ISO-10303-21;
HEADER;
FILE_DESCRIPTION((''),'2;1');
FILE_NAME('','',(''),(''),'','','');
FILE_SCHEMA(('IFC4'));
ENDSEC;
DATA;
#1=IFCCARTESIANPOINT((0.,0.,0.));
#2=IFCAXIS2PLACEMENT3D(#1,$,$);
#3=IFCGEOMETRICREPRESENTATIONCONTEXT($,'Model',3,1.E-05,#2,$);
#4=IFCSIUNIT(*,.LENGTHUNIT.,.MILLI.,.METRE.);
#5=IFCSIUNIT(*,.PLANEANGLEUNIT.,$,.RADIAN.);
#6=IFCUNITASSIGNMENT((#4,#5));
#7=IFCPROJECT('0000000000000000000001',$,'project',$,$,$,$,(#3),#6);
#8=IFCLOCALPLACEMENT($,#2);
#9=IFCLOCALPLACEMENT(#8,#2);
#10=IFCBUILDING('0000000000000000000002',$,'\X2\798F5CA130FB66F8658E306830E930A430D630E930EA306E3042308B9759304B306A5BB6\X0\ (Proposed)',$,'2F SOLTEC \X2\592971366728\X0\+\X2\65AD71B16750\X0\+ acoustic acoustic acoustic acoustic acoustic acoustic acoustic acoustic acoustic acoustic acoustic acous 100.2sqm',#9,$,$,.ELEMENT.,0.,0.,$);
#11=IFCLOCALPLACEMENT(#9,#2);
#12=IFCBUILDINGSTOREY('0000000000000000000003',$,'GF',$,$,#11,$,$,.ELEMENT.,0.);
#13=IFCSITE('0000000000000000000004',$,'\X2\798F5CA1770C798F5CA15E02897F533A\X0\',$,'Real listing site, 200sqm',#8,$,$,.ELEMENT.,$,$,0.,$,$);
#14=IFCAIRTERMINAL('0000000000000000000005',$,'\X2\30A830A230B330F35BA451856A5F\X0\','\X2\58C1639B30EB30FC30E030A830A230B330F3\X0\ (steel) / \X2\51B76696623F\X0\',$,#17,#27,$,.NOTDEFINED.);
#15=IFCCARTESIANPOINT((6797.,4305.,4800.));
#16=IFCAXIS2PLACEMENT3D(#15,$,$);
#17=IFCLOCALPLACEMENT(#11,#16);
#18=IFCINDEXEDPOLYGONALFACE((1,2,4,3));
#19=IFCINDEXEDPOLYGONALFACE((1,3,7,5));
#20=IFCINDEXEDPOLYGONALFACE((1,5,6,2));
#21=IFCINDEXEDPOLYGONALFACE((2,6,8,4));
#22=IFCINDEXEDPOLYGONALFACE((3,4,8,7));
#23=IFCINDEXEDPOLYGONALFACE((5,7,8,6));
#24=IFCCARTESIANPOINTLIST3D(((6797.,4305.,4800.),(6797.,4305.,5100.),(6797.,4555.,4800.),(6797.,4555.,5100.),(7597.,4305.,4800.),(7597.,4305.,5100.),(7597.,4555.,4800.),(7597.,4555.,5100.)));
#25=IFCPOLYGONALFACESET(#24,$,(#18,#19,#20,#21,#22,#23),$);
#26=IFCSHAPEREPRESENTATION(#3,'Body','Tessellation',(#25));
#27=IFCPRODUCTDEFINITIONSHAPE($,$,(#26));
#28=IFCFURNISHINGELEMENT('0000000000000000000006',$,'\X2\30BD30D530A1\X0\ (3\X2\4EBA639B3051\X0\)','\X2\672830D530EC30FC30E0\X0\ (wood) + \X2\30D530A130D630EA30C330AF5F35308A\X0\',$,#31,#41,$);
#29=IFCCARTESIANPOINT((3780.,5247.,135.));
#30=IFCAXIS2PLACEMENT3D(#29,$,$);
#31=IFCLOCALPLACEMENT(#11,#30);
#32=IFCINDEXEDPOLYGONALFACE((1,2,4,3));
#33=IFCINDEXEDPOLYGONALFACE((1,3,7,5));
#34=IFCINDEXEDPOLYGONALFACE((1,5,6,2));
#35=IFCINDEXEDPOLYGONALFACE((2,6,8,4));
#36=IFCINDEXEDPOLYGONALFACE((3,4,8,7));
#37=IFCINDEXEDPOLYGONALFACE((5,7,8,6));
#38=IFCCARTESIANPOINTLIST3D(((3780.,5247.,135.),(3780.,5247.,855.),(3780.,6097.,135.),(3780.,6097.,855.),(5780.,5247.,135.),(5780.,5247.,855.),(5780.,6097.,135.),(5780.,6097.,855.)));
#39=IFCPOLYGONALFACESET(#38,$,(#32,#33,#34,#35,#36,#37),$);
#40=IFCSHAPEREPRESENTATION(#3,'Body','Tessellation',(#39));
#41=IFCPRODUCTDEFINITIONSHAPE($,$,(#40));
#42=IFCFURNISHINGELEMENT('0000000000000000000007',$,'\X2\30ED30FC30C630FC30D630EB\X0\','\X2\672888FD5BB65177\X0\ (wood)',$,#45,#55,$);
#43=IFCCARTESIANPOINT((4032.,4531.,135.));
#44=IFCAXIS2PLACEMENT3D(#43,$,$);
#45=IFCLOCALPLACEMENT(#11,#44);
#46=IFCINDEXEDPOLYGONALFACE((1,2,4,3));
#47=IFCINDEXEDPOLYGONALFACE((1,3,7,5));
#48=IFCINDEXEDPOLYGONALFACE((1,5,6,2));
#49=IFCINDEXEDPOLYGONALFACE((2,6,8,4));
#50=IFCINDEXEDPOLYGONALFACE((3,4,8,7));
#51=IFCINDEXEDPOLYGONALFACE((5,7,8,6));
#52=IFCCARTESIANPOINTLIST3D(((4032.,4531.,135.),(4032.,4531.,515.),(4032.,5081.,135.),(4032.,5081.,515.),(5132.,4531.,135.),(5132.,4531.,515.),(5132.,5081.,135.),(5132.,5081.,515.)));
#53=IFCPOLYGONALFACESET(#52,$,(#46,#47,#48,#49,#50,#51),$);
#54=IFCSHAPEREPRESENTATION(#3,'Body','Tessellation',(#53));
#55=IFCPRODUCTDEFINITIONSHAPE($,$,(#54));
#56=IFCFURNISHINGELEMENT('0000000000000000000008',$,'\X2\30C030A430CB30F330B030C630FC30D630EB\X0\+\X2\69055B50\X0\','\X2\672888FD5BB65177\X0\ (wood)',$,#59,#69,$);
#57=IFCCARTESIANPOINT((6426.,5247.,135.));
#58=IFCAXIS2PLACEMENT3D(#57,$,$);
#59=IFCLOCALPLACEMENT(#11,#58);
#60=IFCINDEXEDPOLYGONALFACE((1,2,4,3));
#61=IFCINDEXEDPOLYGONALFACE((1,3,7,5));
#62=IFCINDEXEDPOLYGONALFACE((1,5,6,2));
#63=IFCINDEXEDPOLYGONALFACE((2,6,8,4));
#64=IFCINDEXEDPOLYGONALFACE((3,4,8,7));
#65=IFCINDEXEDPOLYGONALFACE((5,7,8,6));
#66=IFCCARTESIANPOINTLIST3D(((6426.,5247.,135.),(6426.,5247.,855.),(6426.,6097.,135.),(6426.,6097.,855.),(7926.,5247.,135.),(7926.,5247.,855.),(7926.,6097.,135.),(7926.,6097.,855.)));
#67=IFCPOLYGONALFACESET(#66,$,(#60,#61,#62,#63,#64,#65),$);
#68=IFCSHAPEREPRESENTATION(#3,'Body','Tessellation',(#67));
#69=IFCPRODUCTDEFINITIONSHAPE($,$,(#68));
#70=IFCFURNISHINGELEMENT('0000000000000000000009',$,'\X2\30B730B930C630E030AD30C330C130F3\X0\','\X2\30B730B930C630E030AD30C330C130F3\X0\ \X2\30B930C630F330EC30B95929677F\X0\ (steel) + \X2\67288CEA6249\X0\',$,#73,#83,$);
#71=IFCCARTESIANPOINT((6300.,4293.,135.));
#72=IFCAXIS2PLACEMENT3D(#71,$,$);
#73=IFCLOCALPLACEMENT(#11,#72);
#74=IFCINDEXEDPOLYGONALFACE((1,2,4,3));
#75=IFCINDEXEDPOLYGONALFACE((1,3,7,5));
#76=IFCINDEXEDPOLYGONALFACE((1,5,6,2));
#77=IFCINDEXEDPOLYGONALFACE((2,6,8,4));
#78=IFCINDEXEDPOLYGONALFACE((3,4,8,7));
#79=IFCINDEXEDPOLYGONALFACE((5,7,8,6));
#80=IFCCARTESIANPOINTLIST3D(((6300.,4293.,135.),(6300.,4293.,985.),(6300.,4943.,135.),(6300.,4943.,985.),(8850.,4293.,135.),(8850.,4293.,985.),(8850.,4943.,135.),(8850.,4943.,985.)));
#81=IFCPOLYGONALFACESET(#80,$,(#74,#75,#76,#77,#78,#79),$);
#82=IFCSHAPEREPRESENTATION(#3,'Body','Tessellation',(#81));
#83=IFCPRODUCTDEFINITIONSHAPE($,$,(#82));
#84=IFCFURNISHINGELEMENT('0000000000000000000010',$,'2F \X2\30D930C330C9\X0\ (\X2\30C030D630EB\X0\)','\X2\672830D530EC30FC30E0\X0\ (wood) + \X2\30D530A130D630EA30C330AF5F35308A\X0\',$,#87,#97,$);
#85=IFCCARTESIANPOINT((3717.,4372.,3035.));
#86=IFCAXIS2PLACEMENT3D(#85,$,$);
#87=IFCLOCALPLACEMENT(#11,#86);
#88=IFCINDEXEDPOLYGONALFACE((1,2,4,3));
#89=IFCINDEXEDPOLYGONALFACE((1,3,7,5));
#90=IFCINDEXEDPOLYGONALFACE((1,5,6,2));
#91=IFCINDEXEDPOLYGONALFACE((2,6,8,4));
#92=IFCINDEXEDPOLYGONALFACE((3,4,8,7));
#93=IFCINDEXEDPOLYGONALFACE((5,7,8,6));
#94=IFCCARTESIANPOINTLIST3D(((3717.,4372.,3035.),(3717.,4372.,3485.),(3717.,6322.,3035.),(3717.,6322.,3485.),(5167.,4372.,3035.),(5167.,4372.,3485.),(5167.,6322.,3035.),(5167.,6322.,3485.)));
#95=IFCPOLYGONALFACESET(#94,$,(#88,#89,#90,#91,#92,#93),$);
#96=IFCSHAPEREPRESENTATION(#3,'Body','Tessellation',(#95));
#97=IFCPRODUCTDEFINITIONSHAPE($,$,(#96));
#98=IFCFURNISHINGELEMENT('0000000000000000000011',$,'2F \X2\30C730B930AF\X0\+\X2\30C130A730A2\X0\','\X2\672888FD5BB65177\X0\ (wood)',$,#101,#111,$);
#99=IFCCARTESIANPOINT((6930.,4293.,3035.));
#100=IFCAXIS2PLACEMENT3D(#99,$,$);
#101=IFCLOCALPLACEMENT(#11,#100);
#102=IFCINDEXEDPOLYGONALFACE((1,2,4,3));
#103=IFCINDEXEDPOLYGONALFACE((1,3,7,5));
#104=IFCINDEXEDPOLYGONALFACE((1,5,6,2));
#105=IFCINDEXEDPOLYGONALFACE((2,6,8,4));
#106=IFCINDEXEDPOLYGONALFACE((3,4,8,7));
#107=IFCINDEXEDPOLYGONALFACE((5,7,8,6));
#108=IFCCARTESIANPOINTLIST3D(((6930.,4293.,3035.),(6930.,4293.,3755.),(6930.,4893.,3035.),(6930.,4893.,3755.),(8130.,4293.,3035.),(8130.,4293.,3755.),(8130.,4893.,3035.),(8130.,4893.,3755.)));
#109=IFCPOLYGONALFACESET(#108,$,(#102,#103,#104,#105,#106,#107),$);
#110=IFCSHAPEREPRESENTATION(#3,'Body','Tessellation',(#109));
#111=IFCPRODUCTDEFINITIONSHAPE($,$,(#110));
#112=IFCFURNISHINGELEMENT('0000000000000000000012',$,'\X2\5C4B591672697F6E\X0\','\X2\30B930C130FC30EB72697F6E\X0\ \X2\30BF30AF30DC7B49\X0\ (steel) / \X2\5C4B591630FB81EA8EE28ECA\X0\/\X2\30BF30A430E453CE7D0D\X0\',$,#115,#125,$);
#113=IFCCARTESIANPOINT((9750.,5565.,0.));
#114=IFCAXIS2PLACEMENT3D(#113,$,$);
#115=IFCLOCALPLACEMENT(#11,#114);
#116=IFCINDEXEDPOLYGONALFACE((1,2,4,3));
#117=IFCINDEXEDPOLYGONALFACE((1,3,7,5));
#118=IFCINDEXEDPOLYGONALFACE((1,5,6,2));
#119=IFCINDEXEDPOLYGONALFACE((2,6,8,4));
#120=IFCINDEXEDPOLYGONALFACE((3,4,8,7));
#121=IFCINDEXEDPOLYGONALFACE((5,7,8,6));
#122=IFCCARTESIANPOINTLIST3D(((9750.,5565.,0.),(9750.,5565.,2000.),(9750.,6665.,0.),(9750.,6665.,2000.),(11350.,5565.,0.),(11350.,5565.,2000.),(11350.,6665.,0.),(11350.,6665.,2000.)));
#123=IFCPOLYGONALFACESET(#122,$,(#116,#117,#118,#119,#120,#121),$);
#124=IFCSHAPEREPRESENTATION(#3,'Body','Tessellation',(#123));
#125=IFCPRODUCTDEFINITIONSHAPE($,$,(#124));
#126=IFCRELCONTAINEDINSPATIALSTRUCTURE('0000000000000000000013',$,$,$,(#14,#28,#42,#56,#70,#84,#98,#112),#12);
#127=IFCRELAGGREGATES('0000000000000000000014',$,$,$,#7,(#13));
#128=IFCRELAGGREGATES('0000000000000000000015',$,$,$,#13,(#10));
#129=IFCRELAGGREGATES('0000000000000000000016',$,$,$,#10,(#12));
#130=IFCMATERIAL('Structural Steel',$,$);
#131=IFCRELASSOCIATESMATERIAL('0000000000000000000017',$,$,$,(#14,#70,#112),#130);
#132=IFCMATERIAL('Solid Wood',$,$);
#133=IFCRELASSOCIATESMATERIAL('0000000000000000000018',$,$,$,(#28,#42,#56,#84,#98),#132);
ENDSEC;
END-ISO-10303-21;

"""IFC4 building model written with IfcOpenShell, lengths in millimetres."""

from ifc_helpers import new_model, si_unit, frame, frame_2d, origin, place, context, project, spatial, rectangle, extrude, material, element, save


model = new_model("IFC4")

# Units and contexts
model_context = context("Model", 3, precision=1e-05, world=origin())
ifc_project = project(units=[si_unit("LENGTHUNIT", "METRE", prefix="MILLI"), si_unit("PLANEANGLEUNIT", "RADIAN")], contexts=[model_context])

# Site, building, storey
site_placement = place(None, origin())
site = spatial("IfcSite", under=ifc_project, at=site_placement, Name="福岡県福岡市西区", ObjectType="Real listing site, 200sqm", CompositionType="ELEMENT", RefElevation=0.0)
building_placement = place(site_placement, origin())
building = spatial("IfcBuilding", under=site, at=building_placement, Name="福岡・書斎とライブラリのある静かな家 (Proposed)", ObjectType="2F SOLTEC 天然木+断熱材+ acoustic acoustic acoustic acoustic acoustic acoustic acoustic acoustic acoustic acoustic acoustic acous 100.2sqm", CompositionType="ELEMENT", ElevationOfRefHeight=0.0, ElevationOfTerrain=0.0)
storey_placement = place(building_placement, origin())
storey = spatial("IfcBuildingStorey", under=building, at=storey_placement, Name="GF", CompositionType="ELEMENT", Elevation=0.0)

# Shared definitions
ifc_material_1 = material(Name="Solid Wood")

# Shared definitions
ifc_material_2 = material(Name="Structural Steel")

# Air terminal
air_terminal_1_placement = place(storey_placement, frame((6797.0, 4305.0, 4800.0)))
element("IfcAirTerminal", 1, at=air_terminal_1_placement, inside=storey, material=ifc_material_2, Name="エアコン室内機", Description="壁掛ルームエアコン (steel) / 冷暖房", PredefinedType="NOTDEFINED", context=model_context, shape_type="SweptSolid", body=[
    extrude(rectangle(XDim=800.0, YDim=250.0, at=frame_2d((400.0, 125.0))), frame((6797.0, 4305.0, 4800.0)), (0.0, 0.0, 1.0), 300.0),
])

# Furnishing elements
furnishing_1_placement = place(storey_placement, frame((3780.0, 5247.0, 135.0)))
element("IfcFurnishingElement", 2, at=furnishing_1_placement, inside=storey, material=ifc_material_1, Name="ソファ (3人掛け)", Description="木フレーム (wood) + ファブリック張り", context=model_context, shape_type="SweptSolid", body=[
    extrude(rectangle(XDim=2000.0, YDim=850.0, at=frame_2d((1000.0, 425.0))), frame((3780.0, 5247.0, 135.0)), (0.0, 0.0, 1.0), 720.0),
])
furnishing_2_placement = place(storey_placement, frame((4032.0, 4531.0, 135.0)))
element("IfcFurnishingElement", 3, at=furnishing_2_placement, inside=storey, material=ifc_material_1, Name="ローテーブル", Description="木製家具 (wood)", context=model_context, shape_type="SweptSolid", body=[
    extrude(rectangle(XDim=1100.0, YDim=550.0, at=frame_2d((550.0, 275.0))), frame((4032.0, 4531.0, 135.0)), (0.0, 0.0, 1.0), 380.0),
])
furnishing_3_placement = place(storey_placement, frame((6426.0, 5247.0, 135.0)))
element("IfcFurnishingElement", 4, at=furnishing_3_placement, inside=storey, material=ifc_material_1, Name="ダイニングテーブル+椅子", Description="木製家具 (wood)", context=model_context, shape_type="SweptSolid", body=[
    extrude(rectangle(XDim=1500.0, YDim=850.0, at=frame_2d((750.0, 425.0))), frame((6426.0, 5247.0, 135.0)), (0.0, 0.0, 1.0), 720.0),
])
furnishing_4_placement = place(storey_placement, frame((6300.0, 4293.0, 135.0)))
element("IfcFurnishingElement", 5, at=furnishing_4_placement, inside=storey, material=ifc_material_2, Name="システムキッチン", Description="システムキッチン ステンレス天板 (steel) + 木質扉", context=model_context, shape_type="SweptSolid", body=[
    extrude(rectangle(XDim=2550.0, YDim=650.0, at=frame_2d((1275.0, 325.0))), frame((6300.0, 4293.0, 135.0)), (0.0, 0.0, 1.0), 850.0),
])
furnishing_5_placement = place(storey_placement, frame((3717.0, 4372.0, 3035.0)))
element("IfcFurnishingElement", 6, at=furnishing_5_placement, inside=storey, material=ifc_material_1, Name="2F ベッド (ダブル)", Description="木フレーム (wood) + ファブリック張り", context=model_context, shape_type="SweptSolid", body=[
    extrude(rectangle(XDim=1450.0, YDim=1950.0, at=frame_2d((725.0, 975.0))), frame((3717.0, 4372.0, 3035.0)), (0.0, 0.0, 1.0), 450.0),
])
furnishing_6_placement = place(storey_placement, frame((6930.0, 4293.0, 3035.0)))
element("IfcFurnishingElement", 7, at=furnishing_6_placement, inside=storey, material=ifc_material_1, Name="2F デスク+チェア", Description="木製家具 (wood)", context=model_context, shape_type="SweptSolid", body=[
    extrude(rectangle(XDim=1200.0, YDim=600.0, at=frame_2d((600.0, 300.0))), frame((6930.0, 4293.0, 3035.0)), (0.0, 0.0, 1.0), 720.0),
])
furnishing_7_placement = place(storey_placement, frame((9750.0, 5565.0, 0.0)))
element("IfcFurnishingElement", 8, at=furnishing_7_placement, inside=storey, material=ifc_material_2, Name="屋外物置", Description="スチール物置 タクボ等 (steel) / 屋外・自転車/タイヤ収納", context=model_context, shape_type="SweptSolid", body=[
    extrude(rectangle(XDim=1600.0, YDim=1100.0, at=frame_2d((800.0, 550.0))), frame((9750.0, 5565.0, 0.0)), (0.0, 0.0, 1.0), 2000.0),
])

save(model, "model.ifc")
